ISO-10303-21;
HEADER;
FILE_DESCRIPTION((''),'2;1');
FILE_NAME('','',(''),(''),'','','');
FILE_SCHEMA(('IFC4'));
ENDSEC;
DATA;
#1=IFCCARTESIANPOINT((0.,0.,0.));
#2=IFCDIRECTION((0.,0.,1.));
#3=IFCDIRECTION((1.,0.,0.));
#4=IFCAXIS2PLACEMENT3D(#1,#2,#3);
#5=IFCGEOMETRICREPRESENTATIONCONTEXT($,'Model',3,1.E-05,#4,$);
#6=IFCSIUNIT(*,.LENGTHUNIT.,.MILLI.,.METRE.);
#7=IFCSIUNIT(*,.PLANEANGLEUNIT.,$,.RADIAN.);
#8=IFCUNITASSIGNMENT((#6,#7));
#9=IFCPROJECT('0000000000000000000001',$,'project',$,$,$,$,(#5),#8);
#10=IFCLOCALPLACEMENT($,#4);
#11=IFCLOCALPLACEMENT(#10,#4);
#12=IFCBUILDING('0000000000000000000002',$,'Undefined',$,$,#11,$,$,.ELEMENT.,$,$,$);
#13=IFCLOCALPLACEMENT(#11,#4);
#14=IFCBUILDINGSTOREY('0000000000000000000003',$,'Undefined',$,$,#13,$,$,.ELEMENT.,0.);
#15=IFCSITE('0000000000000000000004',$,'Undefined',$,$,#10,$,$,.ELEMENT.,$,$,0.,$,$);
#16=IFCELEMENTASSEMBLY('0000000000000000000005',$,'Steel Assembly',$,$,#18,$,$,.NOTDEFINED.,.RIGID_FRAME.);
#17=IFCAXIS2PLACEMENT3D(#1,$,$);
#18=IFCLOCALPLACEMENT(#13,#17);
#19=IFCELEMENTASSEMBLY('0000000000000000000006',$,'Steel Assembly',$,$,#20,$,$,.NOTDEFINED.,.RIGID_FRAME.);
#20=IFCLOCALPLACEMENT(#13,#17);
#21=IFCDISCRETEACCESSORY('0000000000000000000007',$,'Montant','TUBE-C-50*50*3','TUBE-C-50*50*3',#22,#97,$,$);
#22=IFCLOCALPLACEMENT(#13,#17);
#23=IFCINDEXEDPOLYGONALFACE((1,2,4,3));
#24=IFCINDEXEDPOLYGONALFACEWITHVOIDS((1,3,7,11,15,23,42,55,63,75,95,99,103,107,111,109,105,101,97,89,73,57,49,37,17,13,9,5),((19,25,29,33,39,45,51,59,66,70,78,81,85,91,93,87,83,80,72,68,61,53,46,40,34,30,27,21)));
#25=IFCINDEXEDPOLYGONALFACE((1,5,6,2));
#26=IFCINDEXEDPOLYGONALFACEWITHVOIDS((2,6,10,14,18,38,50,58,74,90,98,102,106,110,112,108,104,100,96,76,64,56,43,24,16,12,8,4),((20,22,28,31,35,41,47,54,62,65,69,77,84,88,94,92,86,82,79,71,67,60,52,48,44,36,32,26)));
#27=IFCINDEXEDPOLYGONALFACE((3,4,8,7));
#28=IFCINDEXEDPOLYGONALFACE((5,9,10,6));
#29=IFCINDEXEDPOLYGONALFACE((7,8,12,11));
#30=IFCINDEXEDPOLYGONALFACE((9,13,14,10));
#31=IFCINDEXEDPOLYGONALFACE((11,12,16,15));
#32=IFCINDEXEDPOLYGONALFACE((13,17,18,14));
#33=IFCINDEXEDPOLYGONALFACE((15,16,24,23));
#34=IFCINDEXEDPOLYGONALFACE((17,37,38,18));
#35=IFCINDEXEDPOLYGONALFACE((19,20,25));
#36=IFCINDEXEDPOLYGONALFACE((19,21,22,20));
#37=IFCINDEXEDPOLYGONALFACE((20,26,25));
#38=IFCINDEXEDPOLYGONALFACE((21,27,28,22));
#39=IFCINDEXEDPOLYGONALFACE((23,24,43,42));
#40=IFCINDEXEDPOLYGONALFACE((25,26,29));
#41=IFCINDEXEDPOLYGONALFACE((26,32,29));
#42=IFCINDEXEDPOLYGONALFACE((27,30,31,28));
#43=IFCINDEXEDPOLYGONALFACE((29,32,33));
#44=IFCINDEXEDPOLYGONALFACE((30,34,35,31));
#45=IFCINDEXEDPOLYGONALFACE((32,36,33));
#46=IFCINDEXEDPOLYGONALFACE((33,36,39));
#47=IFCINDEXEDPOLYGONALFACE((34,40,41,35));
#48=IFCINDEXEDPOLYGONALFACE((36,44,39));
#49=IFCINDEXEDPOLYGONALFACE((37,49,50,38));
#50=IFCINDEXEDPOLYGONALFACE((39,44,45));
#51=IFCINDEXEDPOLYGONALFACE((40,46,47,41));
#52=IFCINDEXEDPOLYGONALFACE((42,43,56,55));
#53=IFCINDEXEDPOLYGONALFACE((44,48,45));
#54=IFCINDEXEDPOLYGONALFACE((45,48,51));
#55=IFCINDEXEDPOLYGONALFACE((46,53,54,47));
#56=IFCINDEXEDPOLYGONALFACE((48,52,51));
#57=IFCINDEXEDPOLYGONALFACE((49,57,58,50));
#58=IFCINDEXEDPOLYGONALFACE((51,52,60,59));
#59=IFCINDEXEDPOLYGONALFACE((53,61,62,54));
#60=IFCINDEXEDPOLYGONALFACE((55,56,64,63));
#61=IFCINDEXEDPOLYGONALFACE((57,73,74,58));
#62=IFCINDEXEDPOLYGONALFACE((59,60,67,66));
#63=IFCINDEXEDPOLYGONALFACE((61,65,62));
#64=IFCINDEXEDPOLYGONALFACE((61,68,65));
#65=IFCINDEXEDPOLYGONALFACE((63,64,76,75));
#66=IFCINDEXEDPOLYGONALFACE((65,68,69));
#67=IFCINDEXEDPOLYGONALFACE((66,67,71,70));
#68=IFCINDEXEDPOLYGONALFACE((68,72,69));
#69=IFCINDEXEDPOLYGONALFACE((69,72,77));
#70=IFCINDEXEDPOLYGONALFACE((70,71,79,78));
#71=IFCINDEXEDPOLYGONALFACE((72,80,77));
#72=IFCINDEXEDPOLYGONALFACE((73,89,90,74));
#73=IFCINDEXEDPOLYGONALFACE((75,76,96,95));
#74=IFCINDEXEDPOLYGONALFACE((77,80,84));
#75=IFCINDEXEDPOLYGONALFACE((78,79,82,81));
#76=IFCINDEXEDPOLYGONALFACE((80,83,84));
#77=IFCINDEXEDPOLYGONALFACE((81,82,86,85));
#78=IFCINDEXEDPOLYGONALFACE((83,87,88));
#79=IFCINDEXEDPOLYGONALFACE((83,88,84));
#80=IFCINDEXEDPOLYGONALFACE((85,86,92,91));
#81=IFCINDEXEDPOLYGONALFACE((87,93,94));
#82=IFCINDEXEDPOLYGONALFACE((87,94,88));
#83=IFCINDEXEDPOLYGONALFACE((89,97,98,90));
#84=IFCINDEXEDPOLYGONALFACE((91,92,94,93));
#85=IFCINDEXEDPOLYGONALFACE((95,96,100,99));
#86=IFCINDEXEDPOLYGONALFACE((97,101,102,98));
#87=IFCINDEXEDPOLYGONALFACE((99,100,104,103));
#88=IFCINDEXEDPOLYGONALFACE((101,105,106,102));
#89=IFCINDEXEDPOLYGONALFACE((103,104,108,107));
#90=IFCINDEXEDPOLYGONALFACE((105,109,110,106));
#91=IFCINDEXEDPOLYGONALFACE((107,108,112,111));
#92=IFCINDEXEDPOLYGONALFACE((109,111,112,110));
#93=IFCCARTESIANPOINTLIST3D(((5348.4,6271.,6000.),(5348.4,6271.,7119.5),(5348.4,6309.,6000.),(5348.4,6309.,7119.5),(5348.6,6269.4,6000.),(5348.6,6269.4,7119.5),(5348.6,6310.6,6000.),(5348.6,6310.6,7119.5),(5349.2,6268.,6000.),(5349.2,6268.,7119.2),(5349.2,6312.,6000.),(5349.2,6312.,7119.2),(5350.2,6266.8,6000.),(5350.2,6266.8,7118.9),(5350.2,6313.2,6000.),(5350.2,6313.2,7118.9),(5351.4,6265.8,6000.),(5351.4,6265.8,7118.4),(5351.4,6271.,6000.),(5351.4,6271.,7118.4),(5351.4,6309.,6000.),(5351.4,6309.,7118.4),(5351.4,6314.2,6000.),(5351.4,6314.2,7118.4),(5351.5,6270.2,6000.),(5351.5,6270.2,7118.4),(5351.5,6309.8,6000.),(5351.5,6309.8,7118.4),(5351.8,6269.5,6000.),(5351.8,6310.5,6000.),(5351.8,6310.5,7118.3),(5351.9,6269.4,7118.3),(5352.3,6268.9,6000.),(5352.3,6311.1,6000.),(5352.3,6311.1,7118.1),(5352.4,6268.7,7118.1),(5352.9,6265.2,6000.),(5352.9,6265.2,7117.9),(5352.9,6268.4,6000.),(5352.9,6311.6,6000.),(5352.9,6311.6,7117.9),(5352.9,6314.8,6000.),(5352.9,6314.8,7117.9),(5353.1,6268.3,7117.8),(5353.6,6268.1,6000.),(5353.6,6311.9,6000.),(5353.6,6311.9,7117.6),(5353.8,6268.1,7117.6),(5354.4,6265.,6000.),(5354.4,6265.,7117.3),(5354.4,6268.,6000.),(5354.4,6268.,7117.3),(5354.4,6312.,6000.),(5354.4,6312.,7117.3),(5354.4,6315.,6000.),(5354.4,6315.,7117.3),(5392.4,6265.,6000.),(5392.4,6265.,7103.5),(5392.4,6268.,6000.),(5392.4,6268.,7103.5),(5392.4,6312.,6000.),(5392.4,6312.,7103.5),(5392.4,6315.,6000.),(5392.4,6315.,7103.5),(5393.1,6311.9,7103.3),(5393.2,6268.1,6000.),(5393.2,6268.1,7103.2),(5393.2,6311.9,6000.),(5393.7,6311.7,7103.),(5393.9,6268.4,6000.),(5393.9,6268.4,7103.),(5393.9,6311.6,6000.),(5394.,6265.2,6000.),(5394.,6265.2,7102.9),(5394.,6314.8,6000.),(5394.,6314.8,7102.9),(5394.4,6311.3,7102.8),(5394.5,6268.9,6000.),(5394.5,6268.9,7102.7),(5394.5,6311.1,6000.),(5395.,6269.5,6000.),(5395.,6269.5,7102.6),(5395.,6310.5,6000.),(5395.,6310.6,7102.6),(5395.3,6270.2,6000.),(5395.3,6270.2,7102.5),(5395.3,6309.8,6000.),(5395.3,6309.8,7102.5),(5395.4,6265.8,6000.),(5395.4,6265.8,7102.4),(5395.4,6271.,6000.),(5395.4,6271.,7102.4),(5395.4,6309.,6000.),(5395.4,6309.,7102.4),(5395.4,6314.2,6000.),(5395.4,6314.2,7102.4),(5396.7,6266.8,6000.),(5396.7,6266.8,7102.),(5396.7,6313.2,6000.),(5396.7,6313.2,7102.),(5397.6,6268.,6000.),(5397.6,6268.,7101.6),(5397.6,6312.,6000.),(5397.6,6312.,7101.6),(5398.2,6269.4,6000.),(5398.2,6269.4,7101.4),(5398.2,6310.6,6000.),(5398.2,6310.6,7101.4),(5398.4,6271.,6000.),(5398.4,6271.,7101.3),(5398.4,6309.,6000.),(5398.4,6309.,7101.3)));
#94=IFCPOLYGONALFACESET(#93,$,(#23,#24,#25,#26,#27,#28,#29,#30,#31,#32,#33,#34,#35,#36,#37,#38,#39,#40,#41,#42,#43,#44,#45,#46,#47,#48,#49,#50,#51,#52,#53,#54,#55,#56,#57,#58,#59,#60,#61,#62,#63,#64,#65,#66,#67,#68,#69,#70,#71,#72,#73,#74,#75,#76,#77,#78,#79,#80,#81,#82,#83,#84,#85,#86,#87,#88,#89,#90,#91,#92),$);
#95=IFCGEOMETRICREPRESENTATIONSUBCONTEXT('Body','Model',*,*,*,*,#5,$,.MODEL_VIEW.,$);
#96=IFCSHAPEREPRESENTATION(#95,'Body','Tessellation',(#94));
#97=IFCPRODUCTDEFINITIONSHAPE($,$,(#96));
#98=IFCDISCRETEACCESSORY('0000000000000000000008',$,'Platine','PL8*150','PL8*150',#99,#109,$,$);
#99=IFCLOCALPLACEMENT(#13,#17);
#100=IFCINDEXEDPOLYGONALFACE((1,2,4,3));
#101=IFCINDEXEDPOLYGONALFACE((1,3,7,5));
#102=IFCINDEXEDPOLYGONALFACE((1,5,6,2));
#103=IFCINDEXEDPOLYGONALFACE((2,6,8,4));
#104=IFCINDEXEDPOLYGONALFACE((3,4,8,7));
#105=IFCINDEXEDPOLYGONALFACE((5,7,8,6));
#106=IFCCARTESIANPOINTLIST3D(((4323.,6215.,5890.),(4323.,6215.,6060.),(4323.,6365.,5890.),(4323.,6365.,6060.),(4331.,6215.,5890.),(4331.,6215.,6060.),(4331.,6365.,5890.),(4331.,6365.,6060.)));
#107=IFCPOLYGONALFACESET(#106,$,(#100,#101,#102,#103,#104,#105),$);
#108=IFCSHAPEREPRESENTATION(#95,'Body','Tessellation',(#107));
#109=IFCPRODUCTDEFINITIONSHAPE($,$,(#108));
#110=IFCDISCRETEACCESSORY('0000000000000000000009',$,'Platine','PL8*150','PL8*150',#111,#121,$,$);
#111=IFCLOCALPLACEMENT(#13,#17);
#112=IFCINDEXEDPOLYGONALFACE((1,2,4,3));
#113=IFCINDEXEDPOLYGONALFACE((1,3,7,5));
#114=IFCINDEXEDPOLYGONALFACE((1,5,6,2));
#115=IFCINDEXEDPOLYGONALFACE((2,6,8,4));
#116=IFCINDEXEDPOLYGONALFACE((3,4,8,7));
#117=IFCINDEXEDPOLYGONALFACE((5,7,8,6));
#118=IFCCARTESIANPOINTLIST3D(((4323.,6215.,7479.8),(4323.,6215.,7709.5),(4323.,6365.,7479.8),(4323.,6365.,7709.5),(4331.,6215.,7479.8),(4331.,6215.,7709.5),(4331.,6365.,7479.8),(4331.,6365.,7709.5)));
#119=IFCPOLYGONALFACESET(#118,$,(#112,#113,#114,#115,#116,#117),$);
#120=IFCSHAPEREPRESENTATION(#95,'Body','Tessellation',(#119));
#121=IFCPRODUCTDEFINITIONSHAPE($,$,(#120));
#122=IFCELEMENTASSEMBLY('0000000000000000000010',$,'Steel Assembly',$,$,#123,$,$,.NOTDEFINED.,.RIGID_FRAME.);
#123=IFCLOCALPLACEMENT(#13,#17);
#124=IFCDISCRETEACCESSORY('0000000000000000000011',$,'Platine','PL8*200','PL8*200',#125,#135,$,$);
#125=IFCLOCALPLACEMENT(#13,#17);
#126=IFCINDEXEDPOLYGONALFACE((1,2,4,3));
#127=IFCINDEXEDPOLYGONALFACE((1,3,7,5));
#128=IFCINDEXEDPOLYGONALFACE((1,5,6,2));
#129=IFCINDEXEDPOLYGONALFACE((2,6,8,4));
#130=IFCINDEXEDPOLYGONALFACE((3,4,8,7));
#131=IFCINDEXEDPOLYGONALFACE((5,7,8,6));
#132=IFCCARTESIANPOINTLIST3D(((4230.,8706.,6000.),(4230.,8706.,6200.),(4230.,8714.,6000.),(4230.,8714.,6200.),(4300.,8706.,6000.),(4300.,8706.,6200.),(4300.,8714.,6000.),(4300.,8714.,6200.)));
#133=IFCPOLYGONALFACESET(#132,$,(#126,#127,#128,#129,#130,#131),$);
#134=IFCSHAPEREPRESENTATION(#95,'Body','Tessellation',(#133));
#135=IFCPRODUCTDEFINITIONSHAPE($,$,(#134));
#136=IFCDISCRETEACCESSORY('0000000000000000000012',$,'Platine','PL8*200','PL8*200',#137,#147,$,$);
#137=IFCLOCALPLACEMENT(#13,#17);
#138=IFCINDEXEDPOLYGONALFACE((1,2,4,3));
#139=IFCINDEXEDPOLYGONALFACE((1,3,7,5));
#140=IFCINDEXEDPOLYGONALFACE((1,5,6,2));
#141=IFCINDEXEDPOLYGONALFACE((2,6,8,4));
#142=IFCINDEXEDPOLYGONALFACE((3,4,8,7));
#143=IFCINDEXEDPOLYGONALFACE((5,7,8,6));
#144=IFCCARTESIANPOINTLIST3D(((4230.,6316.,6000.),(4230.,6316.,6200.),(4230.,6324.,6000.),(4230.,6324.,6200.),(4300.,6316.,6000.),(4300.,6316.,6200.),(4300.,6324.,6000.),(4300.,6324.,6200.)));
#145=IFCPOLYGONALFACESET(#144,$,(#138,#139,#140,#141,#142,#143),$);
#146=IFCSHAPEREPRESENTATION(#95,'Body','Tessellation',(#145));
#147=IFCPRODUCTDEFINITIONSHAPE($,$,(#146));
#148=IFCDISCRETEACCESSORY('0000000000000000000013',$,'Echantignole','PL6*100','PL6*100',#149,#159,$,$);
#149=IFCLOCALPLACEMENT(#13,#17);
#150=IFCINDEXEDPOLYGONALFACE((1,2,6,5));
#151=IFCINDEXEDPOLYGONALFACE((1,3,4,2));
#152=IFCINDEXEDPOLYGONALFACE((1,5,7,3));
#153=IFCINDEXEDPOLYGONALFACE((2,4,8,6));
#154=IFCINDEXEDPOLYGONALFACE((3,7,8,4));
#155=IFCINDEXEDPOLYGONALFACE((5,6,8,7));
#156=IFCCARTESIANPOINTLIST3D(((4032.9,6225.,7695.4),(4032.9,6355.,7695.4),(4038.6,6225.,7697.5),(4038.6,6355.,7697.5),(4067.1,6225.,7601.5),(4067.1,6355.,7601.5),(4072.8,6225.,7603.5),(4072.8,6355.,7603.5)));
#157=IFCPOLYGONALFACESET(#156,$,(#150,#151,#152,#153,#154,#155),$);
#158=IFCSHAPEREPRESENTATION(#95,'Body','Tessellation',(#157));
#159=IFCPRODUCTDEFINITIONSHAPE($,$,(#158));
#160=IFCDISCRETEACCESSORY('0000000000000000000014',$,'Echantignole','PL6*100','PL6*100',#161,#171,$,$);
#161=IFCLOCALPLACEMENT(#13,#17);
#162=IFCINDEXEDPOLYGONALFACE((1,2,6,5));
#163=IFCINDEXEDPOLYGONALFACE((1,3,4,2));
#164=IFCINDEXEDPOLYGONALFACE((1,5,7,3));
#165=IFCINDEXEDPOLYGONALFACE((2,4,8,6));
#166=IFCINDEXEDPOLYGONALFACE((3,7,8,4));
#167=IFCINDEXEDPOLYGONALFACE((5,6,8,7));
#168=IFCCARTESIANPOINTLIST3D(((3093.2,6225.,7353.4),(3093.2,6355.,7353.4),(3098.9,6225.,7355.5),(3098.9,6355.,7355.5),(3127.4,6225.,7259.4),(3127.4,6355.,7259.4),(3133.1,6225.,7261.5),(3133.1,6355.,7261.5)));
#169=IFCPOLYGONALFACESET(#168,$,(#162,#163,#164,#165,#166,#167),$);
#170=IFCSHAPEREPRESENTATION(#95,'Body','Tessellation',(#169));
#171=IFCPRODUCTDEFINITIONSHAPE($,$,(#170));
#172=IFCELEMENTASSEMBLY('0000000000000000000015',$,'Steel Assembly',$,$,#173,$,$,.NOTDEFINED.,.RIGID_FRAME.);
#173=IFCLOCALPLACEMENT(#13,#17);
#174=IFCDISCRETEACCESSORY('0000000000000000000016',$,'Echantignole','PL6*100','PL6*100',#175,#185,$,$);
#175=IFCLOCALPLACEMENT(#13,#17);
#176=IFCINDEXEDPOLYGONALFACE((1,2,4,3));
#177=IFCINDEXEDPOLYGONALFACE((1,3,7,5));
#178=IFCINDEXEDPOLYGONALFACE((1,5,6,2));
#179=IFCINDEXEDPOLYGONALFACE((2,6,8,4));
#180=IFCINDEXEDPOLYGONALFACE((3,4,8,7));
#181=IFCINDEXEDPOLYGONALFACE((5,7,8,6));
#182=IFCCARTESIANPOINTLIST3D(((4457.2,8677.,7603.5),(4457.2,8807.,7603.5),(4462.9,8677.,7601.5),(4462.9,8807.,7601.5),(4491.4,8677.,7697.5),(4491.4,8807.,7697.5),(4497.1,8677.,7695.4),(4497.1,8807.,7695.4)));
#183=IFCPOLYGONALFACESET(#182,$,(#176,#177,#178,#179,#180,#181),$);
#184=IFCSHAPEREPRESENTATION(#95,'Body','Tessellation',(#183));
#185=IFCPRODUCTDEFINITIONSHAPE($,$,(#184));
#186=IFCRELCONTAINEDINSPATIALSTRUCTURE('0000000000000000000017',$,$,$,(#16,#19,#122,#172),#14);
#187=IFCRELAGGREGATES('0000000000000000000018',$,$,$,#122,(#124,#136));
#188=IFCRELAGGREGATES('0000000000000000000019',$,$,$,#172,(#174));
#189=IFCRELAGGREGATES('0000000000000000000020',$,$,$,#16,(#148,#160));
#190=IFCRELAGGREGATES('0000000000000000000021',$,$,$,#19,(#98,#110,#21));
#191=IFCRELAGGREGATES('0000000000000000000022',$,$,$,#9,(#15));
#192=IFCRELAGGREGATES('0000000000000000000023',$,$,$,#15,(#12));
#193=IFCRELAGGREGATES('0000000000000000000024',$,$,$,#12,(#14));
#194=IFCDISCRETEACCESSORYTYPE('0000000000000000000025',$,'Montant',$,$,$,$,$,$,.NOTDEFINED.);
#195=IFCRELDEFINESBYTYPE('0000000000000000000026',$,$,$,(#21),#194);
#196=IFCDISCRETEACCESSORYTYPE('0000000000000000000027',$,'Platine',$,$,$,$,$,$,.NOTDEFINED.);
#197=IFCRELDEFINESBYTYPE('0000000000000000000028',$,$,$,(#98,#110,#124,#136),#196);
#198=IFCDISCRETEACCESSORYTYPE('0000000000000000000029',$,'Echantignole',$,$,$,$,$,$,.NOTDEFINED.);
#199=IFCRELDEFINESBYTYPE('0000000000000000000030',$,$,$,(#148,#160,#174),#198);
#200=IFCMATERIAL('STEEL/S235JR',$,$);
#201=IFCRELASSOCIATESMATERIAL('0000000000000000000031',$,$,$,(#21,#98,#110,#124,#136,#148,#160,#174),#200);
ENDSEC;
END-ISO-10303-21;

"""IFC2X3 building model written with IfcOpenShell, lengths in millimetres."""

from ifc_helpers import new_model, si_unit, frame, origin_with_axes, origin_2d_with_axis, place, context, subcontext, project, spatial, polyline, hollow_rectangle, outline, extrude, clip, halfspace, material, type_object, element, aggregate, save


model = new_model("IFC2X3")

# Units and contexts
model_context = context("Model", 3, precision=1e-05, world=origin_with_axes())
body_context = subcontext(model_context, "Body", "Model", "MODEL_VIEW")
ifc_project = project(units=[si_unit("LENGTHUNIT", "METRE", prefix="MILLI"), si_unit("PLANEANGLEUNIT", "RADIAN")], contexts=[model_context])

# Site, building, storey
site_placement = place(None, origin_with_axes())
site = spatial("IfcSite", under=ifc_project, at=site_placement, Name="Undefined", CompositionType="ELEMENT", RefElevation=0.0)
building_placement = place(site_placement, origin_with_axes())
building = spatial("IfcBuilding", under=site, at=building_placement, Name="Undefined", CompositionType="ELEMENT")
storey_placement = place(building_placement, origin_with_axes())
storey = spatial("IfcBuildingStorey", under=building, at=storey_placement, Name="Undefined", CompositionType="ELEMENT", Elevation=0.0)

# Shared definitions
ifc_material_1 = material(Name="STEEL/S235JR")

# Element assemblies, discrete accessory
assembly_1_placement = place(storey_placement, origin_with_axes())
assembly_1 = element("IfcElementAssembly", 1, at=assembly_1_placement, inside=storey, Name="Steel Assembly", AssemblyPlace="NOTDEFINED", PredefinedType="RIGID_FRAME")
discrete_accessory_type_1 = type_object("IfcDiscreteAccessoryType", Name="Montant")
assembly_2_placement = place(storey_placement, origin_with_axes())
assembly_2 = element("IfcElementAssembly", 2, at=assembly_2_placement, inside=storey, Name="Steel Assembly", AssemblyPlace="NOTDEFINED", PredefinedType="RIGID_FRAME")
discrete_accessory_1_placement = place(assembly_2_placement, frame((5373.4, 6290.0, 6000.0), z_axis=(0.0, 0.0, 1.0), x_axis=(1.0, 0.0, 0.0)))
discrete_accessory_1 = element("IfcDiscreteAccessory", 3, at=discrete_accessory_1_placement, type_object=discrete_accessory_type_1, material=ifc_material_1, Name="Montant", Description="TUBE-C-50*50*3", ObjectType="TUBE-C-50*50*3", context=body_context, shape_type="Clipping", body=[
    clip(extrude(hollow_rectangle(XDim=50.0, YDim=50.0, WallThickness=3.0, InnerFilletRadius=3.0, OuterFilletRadius=6.0, at=origin_2d_with_axis()), frame((0.0, 0.0, 1119.6), z_axis=(0.0, 0.0, -1.0), x_axis=(0.0, -1.0, 0.0)), (0.0, 0.0, 1.0), 1119.6), halfspace(frame((32.9, 0.0, 1098.4), z_axis=(0.34202, 0.0, 0.939693), x_axis=(0.0, -1.0, 0.0)), False)),
])

# Discrete accessories
discrete_accessory_type_2 = type_object("IfcDiscreteAccessoryType", Name="Platine")
discrete_accessory_2_placement = place(assembly_2_placement, frame((4327.0, 6290.0, 5890.0), z_axis=(1.0, 0.0, 0.0), x_axis=(0.0, 0.0, 1.0)))
discrete_accessory_2 = element("IfcDiscreteAccessory", 4, at=discrete_accessory_2_placement, type_object=discrete_accessory_type_2, material=ifc_material_1, Name="Platine", Description="PL8*150", ObjectType="PL8*150", context=body_context, shape_type="SweptSolid", body=[
    extrude(outline(polyline([(170.0, 75.0), (170.0, -75.0), (0.0, -75.0), (0.0, 75.0), (170.0, 75.0)])), frame((0.0, 0.0, -4.0), z_axis=(0.0, 0.0, 1.0), x_axis=(1.0, 0.0, 0.0)), (0.0, 0.0, 1.0), 8.0),
])
discrete_accessory_3_placement = place(assembly_2_placement, frame((4327.0, 6290.0, 7479.8), z_axis=(1.0, 0.0, 0.0), x_axis=(0.0, 0.0, 1.0)))
discrete_accessory_3 = element("IfcDiscreteAccessory", 5, at=discrete_accessory_3_placement, type_object=discrete_accessory_type_2, material=ifc_material_1, Name="Platine", Description="PL8*150", ObjectType="PL8*150", context=body_context, shape_type="SweptSolid", body=[
    extrude(outline(polyline([(229.6, 75.0), (229.6, -75.0), (0.0, -75.0), (0.0, 75.0), (229.6, 75.0)])), frame((0.0, 0.0, -4.0), z_axis=(0.0, 0.0, 1.0), x_axis=(1.0, 0.0, 0.0)), (0.0, 0.0, 1.0), 8.0),
])

# Element assembly, discrete accessories
assembly_3_placement = place(storey_placement, origin_with_axes())
assembly_3 = element("IfcElementAssembly", 6, at=assembly_3_placement, inside=storey, Name="Steel Assembly", AssemblyPlace="NOTDEFINED", PredefinedType="RIGID_FRAME")
discrete_accessory_4_placement = place(assembly_3_placement, frame((4300.0, 8710.0, 6100.0), z_axis=(0.0, -1.0, 0.0), x_axis=(-1.0, 0.0, 0.0)))
discrete_accessory_4 = element("IfcDiscreteAccessory", 7, at=discrete_accessory_4_placement, type_object=discrete_accessory_type_2, material=ifc_material_1, Name="Platine", Description="PL8*200", ObjectType="PL8*200", context=body_context, shape_type="SweptSolid", body=[
    extrude(outline(polyline([(70.0, -100.0), (0.0, -100.0), (0.0, 100.0), (70.0, 100.0), (70.0, -100.0)])), frame((0.0, 0.0, -4.0), z_axis=(0.0, 0.0, 1.0), x_axis=(1.0, 0.0, 0.0)), (0.0, 0.0, 1.0), 8.0),
])
discrete_accessory_5_placement = place(assembly_3_placement, frame((4300.0, 6320.0, 6100.0), z_axis=(0.0, 1.0, 0.0), x_axis=(-1.0, 0.0, 0.0)))
discrete_accessory_5 = element("IfcDiscreteAccessory", 8, at=discrete_accessory_5_placement, type_object=discrete_accessory_type_2, material=ifc_material_1, Name="Platine", Description="PL8*200", ObjectType="PL8*200", context=body_context, shape_type="SweptSolid", body=[
    extrude(outline(polyline([(0.0, -100.0), (0.0, 100.0), (70.0, 100.0), (70.0, -100.0), (0.0, -100.0)])), frame((0.0, 0.0, -4.0), z_axis=(0.0, 0.0, 1.0), x_axis=(1.0, 0.0, 0.0)), (0.0, 0.0, 1.0), 8.0),
])
aggregate(assembly_3, [discrete_accessory_4, discrete_accessory_5])

# Discrete accessories
discrete_accessory_type_3 = type_object("IfcDiscreteAccessoryType", Name="Echantignole")
discrete_accessory_6_placement = place(assembly_1_placement, frame((4052.9, 6355.0, 7649.5), z_axis=(-0.939693, 0.0, -0.34202), x_axis=(0.0, -1.0, 0.0)))
discrete_accessory_6 = element("IfcDiscreteAccessory", 9, at=discrete_accessory_6_placement, type_object=discrete_accessory_type_3, material=ifc_material_1, Name="Echantignole", Description="PL6*100", ObjectType="PL6*100", context=body_context, shape_type="SweptSolid", body=[
    extrude(outline(polyline([(130.0, -50.0), (0.0, -50.0), (0.0, 50.0), (130.0, 50.0), (130.0, -50.0)])), frame((0.0, 0.0, -3.0), z_axis=(0.0, 0.0, 1.0), x_axis=(1.0, 0.0, 0.0)), (0.0, 0.0, 1.0), 6.0),
])
discrete_accessory_7_placement = place(assembly_1_placement, frame((3113.2, 6355.0, 7307.5), z_axis=(-0.939693, 0.0, -0.34202), x_axis=(0.0, -1.0, 0.0)))
discrete_accessory_7 = element("IfcDiscreteAccessory", 10, at=discrete_accessory_7_placement, type_object=discrete_accessory_type_3, material=ifc_material_1, Name="Echantignole", Description="PL6*100", ObjectType="PL6*100", context=body_context, shape_type="SweptSolid", body=[
    extrude(outline(polyline([(130.0, -50.0), (0.0, -50.0), (0.0, 50.0), (130.0, 50.0), (130.0, -50.0)])), frame((0.0, 0.0, -3.0), z_axis=(0.0, 0.0, 1.0), x_axis=(1.0, 0.0, 0.0)), (0.0, 0.0, 1.0), 6.0),
])

# Element assembly, discrete accessory
assembly_4_placement = place(storey_placement, origin_with_axes())
assembly_4 = element("IfcElementAssembly", 11, at=assembly_4_placement, inside=storey, Name="Steel Assembly", AssemblyPlace="NOTDEFINED", PredefinedType="RIGID_FRAME")
discrete_accessory_8_placement = place(assembly_4_placement, frame((4477.2, 8677.0, 7649.5), z_axis=(0.939693, 0.0, -0.34202), x_axis=(0.0, 1.0, 0.0)))
discrete_accessory_8 = element("IfcDiscreteAccessory", 12, at=discrete_accessory_8_placement, type_object=discrete_accessory_type_3, material=ifc_material_1, Name="Echantignole", Description="PL6*100", ObjectType="PL6*100", context=body_context, shape_type="SweptSolid", body=[
    extrude(outline(polyline([(0.0, 50.0), (130.0, 50.0), (130.0, -50.0), (0.0, -50.0), (0.0, 50.0)])), frame((0.0, 0.0, -3.0), z_axis=(0.0, 0.0, 1.0), x_axis=(1.0, 0.0, 0.0)), (0.0, 0.0, 1.0), 6.0),
])
aggregate(assembly_4, [discrete_accessory_8])

aggregate(assembly_1, [discrete_accessory_6, discrete_accessory_7])
aggregate(assembly_2, [discrete_accessory_2, discrete_accessory_3, discrete_accessory_1])

save(model, "model.ifc")
